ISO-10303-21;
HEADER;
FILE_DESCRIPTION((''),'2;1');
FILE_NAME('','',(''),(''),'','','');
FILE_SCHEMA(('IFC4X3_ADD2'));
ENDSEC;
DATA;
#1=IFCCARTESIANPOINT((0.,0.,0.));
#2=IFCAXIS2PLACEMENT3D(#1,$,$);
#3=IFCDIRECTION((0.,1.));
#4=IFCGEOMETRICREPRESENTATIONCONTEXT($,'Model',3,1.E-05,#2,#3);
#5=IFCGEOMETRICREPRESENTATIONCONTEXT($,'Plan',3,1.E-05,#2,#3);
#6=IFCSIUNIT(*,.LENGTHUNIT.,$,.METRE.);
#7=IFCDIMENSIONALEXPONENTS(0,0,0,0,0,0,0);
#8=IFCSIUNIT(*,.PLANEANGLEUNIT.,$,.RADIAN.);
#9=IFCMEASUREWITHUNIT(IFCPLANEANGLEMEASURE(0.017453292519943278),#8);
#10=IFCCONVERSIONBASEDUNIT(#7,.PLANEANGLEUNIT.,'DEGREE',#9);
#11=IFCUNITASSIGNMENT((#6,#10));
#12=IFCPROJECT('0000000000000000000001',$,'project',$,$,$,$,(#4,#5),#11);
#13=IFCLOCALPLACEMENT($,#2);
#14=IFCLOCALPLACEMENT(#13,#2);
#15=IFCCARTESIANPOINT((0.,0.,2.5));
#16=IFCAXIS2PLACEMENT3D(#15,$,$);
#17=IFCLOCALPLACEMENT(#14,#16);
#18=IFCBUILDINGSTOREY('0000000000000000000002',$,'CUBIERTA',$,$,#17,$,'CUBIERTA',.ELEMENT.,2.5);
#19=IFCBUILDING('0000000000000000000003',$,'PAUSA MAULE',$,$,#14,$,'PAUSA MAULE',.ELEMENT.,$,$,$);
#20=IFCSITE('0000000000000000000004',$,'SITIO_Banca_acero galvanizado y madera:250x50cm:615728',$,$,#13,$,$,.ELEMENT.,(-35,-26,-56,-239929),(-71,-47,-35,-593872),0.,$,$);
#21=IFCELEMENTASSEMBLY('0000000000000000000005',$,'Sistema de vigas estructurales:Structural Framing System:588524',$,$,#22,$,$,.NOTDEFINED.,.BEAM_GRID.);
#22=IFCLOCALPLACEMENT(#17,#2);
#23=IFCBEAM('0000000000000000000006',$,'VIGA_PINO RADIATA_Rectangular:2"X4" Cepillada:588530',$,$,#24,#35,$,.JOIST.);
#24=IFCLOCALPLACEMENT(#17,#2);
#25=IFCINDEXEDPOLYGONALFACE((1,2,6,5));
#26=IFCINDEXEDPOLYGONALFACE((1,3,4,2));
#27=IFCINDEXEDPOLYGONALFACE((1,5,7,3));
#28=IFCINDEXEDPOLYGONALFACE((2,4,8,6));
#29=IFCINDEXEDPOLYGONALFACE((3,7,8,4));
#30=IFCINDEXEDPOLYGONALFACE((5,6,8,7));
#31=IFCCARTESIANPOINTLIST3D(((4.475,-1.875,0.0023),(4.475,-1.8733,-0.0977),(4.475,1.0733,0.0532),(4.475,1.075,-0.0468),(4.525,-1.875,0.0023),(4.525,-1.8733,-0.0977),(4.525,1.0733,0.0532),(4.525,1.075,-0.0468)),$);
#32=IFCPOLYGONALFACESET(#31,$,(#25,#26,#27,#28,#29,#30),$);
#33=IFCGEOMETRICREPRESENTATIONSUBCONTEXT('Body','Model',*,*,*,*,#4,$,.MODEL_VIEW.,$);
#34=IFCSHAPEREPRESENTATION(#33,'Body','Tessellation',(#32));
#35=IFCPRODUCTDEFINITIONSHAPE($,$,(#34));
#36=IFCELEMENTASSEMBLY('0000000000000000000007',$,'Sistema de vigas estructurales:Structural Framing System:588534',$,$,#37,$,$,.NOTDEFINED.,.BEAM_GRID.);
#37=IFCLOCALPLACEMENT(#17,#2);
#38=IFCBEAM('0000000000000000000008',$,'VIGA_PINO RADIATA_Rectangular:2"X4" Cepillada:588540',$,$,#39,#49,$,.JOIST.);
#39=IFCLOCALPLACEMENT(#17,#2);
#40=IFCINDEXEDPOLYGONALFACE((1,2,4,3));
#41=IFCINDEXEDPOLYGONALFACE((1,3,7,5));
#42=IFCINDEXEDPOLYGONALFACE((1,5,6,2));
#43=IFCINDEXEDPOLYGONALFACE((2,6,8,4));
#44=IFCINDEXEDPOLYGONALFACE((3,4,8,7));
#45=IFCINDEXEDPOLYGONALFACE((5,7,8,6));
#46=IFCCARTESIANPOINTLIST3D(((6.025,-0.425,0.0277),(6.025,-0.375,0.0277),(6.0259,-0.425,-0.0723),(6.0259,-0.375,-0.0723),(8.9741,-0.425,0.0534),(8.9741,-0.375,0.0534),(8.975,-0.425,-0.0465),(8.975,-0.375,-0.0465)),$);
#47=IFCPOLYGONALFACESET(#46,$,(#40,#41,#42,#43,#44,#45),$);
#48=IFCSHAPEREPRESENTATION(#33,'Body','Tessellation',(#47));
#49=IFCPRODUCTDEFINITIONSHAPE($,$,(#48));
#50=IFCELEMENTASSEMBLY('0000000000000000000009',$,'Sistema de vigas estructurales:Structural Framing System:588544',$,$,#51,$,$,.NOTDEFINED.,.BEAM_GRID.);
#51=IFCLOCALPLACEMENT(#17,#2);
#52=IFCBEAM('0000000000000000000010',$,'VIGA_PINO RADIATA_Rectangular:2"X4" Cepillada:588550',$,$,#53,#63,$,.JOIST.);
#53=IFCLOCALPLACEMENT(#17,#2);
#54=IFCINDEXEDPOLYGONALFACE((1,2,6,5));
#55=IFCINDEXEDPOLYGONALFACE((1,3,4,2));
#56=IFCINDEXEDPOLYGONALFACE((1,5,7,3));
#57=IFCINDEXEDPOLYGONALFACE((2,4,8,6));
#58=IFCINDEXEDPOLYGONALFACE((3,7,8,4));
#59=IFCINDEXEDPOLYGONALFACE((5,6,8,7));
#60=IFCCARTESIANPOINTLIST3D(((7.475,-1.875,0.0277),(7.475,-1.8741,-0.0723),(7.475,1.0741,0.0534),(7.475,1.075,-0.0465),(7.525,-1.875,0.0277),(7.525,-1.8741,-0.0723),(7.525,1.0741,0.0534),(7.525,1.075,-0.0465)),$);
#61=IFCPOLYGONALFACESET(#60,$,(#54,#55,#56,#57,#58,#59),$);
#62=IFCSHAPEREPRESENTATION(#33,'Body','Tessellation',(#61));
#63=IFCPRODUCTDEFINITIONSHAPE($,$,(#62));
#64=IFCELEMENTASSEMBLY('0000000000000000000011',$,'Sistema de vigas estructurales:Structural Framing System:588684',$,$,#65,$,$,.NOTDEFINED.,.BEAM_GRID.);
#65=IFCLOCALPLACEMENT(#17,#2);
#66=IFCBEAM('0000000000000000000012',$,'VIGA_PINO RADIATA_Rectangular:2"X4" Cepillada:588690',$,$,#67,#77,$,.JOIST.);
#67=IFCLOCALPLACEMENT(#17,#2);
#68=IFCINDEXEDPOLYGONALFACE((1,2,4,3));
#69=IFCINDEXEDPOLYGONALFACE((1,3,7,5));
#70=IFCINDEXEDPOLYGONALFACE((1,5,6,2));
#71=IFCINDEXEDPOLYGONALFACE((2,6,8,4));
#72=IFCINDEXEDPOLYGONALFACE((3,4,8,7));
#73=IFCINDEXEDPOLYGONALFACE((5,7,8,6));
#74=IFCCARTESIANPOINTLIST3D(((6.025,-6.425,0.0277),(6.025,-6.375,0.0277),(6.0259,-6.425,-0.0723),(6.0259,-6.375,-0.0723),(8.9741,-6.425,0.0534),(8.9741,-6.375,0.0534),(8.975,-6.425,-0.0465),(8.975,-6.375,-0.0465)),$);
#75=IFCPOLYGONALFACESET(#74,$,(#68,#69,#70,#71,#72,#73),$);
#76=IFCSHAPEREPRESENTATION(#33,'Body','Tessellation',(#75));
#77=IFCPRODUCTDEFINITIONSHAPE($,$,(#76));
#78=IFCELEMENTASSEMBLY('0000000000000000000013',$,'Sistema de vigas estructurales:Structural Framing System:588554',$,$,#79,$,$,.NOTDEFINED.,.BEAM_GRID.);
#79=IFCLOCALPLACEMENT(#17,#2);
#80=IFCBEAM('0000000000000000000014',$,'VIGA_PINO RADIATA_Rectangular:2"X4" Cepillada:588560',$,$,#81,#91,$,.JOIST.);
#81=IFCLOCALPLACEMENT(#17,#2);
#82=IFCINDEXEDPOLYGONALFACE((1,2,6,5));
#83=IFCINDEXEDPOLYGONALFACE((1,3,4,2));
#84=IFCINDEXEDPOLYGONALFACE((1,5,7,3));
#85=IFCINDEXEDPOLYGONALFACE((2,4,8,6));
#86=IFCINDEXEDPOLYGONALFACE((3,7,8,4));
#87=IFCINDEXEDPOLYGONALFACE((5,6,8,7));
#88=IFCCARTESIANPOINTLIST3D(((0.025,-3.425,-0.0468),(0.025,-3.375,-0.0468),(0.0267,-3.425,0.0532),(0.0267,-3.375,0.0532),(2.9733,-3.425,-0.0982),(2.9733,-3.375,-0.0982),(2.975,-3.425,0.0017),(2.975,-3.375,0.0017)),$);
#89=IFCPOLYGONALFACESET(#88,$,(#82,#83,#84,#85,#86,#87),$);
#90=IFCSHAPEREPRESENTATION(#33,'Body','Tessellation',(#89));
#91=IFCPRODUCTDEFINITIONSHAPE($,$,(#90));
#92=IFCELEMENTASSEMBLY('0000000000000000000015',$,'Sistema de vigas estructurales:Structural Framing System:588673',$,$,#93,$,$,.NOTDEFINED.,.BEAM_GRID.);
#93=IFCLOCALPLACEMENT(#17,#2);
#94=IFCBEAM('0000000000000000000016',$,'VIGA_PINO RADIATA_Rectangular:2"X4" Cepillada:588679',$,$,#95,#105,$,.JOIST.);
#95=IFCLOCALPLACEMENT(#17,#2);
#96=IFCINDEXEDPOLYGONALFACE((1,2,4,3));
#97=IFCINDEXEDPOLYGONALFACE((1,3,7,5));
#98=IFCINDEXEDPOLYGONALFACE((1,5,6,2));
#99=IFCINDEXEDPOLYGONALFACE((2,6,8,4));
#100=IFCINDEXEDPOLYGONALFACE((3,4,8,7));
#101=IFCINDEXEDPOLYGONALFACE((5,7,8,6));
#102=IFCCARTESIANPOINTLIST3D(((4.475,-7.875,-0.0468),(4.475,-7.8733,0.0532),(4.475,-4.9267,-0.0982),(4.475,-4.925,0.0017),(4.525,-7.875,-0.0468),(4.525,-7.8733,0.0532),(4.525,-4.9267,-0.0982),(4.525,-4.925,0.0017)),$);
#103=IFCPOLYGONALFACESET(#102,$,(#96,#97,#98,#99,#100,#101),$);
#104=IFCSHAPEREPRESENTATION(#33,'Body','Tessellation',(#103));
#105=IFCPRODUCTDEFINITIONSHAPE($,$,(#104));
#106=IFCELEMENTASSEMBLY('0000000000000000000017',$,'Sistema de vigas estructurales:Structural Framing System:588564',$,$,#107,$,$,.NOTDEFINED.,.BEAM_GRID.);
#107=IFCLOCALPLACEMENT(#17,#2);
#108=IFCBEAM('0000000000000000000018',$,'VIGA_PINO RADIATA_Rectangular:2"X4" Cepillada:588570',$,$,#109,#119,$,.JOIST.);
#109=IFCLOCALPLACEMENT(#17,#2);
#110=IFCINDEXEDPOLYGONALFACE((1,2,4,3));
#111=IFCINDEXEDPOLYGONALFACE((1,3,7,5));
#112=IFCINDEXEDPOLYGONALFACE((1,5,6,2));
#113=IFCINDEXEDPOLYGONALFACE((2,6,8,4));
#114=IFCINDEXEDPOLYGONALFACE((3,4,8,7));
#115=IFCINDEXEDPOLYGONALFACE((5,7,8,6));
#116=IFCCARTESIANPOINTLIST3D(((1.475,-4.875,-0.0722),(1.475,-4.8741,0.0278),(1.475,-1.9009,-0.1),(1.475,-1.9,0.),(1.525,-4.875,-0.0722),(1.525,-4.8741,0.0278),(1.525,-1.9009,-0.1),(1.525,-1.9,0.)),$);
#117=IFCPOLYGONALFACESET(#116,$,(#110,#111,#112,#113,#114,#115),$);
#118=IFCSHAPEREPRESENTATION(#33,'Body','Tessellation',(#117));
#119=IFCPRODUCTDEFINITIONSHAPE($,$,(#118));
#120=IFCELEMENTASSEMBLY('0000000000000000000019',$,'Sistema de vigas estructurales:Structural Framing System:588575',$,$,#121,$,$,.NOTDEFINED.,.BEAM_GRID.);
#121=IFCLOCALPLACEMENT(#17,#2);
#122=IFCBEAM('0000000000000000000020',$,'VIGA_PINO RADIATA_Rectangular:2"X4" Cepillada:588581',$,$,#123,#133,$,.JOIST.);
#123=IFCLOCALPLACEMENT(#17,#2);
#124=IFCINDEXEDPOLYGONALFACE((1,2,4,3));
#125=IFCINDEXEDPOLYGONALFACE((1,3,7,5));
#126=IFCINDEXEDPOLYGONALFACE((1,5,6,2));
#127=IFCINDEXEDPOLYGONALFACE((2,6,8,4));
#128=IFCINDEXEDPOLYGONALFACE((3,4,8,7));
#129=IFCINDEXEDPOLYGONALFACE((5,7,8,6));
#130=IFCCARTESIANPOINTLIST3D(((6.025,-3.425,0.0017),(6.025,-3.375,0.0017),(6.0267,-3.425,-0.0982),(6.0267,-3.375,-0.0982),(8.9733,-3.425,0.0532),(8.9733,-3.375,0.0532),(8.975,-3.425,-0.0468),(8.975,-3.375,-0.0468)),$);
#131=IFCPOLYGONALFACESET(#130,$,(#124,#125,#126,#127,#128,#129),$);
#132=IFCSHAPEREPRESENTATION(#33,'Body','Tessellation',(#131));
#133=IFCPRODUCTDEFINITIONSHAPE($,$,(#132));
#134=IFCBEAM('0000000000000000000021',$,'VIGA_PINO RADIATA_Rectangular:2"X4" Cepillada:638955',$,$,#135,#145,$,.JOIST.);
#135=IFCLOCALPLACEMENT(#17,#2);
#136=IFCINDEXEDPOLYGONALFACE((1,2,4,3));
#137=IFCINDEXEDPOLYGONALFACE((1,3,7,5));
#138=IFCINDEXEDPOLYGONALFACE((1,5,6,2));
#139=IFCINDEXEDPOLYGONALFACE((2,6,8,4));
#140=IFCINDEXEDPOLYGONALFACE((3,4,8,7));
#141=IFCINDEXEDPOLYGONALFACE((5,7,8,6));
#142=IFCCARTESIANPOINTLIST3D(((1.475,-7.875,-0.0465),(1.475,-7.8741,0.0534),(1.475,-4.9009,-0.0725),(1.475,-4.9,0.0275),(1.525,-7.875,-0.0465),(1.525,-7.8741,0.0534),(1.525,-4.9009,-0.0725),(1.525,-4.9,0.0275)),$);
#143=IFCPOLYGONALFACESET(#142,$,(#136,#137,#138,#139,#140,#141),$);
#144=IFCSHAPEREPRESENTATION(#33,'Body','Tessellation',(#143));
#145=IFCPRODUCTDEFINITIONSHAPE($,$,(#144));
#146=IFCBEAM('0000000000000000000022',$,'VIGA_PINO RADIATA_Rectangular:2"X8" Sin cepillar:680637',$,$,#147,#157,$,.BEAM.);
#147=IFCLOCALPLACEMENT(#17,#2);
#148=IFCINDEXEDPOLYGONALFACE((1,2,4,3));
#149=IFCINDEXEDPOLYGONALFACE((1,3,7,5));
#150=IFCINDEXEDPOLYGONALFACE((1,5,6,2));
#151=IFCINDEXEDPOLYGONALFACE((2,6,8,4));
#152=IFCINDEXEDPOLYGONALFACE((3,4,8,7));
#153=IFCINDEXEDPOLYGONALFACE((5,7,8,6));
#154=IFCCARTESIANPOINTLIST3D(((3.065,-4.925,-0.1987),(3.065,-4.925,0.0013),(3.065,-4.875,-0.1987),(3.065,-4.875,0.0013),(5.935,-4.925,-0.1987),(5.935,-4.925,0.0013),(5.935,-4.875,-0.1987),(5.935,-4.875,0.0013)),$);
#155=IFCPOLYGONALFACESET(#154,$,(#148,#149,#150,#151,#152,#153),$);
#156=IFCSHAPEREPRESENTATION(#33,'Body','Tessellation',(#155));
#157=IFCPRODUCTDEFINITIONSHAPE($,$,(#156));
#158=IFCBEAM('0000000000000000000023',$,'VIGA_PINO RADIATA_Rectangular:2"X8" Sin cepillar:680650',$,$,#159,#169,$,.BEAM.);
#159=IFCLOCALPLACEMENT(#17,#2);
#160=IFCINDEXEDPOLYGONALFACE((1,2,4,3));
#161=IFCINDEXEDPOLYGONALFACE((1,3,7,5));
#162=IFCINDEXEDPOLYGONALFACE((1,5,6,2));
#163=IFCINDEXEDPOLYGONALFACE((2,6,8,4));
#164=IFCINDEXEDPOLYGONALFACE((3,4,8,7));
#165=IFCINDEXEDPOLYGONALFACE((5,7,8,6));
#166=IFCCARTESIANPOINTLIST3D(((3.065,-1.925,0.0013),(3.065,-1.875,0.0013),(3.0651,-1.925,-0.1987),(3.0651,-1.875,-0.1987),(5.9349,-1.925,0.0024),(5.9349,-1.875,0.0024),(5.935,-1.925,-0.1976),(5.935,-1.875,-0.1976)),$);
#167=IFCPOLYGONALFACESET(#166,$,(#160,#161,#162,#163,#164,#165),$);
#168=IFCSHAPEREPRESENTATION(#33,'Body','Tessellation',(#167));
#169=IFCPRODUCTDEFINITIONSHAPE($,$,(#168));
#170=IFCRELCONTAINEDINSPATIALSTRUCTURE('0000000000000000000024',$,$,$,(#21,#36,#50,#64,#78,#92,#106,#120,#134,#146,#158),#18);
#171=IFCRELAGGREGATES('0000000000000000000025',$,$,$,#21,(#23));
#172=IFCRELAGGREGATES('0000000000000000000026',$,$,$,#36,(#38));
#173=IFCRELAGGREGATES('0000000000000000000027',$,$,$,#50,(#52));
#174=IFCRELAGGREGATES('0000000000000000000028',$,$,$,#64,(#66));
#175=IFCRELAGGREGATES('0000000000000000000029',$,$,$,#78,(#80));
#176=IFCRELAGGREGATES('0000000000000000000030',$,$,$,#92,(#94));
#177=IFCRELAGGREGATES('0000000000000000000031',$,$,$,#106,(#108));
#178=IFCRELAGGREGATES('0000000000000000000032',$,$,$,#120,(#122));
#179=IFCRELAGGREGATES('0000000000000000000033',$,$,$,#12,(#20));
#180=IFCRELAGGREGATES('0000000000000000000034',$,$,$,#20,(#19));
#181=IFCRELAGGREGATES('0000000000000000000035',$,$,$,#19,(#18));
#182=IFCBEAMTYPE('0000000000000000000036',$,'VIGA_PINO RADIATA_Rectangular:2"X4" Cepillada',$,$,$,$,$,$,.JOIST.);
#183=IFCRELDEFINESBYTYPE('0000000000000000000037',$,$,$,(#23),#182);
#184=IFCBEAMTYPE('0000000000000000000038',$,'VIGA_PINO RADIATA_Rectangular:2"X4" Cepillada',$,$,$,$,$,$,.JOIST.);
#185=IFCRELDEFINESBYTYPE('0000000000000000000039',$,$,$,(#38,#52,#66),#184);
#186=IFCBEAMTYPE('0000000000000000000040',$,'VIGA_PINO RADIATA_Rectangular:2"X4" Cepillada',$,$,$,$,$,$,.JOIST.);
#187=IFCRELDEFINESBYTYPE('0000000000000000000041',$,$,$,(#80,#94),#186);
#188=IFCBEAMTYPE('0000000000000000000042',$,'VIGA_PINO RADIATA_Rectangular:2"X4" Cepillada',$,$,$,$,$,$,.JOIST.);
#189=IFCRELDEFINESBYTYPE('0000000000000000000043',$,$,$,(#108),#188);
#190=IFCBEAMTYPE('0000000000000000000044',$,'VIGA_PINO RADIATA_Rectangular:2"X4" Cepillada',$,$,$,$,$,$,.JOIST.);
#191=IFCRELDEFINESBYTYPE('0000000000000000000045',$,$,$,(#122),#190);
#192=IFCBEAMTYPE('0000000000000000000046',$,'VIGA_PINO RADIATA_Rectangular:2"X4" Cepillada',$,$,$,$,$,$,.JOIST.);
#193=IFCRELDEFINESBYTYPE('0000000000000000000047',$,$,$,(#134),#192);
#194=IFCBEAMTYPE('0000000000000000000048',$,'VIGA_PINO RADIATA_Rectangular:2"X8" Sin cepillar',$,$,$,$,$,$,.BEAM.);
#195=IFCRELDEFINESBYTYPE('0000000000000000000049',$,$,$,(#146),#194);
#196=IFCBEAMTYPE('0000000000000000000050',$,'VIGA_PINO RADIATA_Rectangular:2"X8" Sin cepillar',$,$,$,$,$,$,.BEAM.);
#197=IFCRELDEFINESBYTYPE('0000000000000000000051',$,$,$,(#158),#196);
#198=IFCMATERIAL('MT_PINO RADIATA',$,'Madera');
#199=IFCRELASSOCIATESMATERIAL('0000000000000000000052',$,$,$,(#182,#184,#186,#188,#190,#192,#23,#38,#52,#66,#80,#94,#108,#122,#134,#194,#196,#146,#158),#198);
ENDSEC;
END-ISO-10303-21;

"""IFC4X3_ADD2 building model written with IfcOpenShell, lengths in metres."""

from ifc_helpers import new_model, entity, si_unit, converted_unit, direction, frame, origin, origin_2d_with_axis, place, context, subcontext, project, spatial, rectangle, extrude, source, transform, mapped, material, material_profile, profile_set, profile_usage, type_object, type_shapes, element, aggregate, save


model = new_model("IFC4X3_ADD2")

# Units and contexts
model_context = context("Model", 3, precision=1e-05, world=origin(), true_north=direction((0.0, 1.0)))
plan_context = context("Plan", 3, precision=1e-05, world=origin(), true_north=direction((0.0, 1.0)))
body_context = subcontext(model_context, "Body", "Model", "MODEL_VIEW")
ifc_project = project(units=[si_unit("LENGTHUNIT", "METRE"), converted_unit("PLANEANGLEUNIT", "DEGREE", entity("IfcPlaneAngleMeasure", 0.017453292519943278), si_unit("PLANEANGLEUNIT", "RADIAN"), dimensions=[0, 0, 0, 0, 0, 0, 0])], contexts=[model_context, plan_context])

# Site, building, storey
site_placement = place(None, origin())
site = spatial("IfcSite", under=ifc_project, at=site_placement, Name="SITIO_Banca_acero galvanizado y madera:250x50cm:615728", CompositionType="ELEMENT", RefLatitude=(-35, -26, -56, -239929), RefLongitude=(-71, -47, -35, -593872), RefElevation=0.0)
building_placement = place(site_placement, origin())
building = spatial("IfcBuilding", under=site, at=building_placement, Name="PAUSA MAULE", LongName="PAUSA MAULE", CompositionType="ELEMENT")
storey_placement = place(building_placement, frame((0.0, 0.0, 2.5)))
storey = spatial("IfcBuildingStorey", under=building, at=storey_placement, Name="CUBIERTA", LongName="CUBIERTA", CompositionType="ELEMENT", Elevation=2.5)

# Shared definitions
ifc_material_1 = material(Name="MT_PINO RADIATA", Category="Madera")
ifc_material_profile_1 = material_profile(ifc_material_1, rectangle(XDim=8.87, YDim=0.05, at=origin_2d_with_axis()), Name="2\"X8\" Sin cepillar")
ifc_profile_set_1 = profile_set([ifc_material_profile_1], Name="2\"X8\" Sin cepillar")
ifc_profile_usage_1 = profile_usage(ifc_profile_set_1, cardinal=8)

# Element assemblies, beams
ifc_material_profile_2 = material_profile(ifc_material_1, rectangle(XDim=2.9493, YDim=0.05, at=origin_2d_with_axis()), Name="2\"X4\" Cepillada")
ifc_profile_set_2 = profile_set([ifc_material_profile_2], Name="2\"X4\" Cepillada")
ifc_profile_usage_2 = profile_usage(ifc_profile_set_2, cardinal=8)
assembly_1_placement = place(storey_placement, origin())
assembly_1 = element("IfcElementAssembly", 1, at=assembly_1_placement, inside=storey, Name="Sistema de vigas estructurales:Structural Framing System:588524", AssemblyPlace="NOTDEFINED", PredefinedType="BEAM_GRID")
beam_type_1 = type_object("IfcBeamType", Name="VIGA_PINO RADIATA_Rectangular:2\"X4\" Cepillada", PredefinedType="JOIST", material=ifc_profile_set_2)
shared_shape_1 = source(origin(), body_context, "Body", "SweptSolid", [
    extrude(rectangle(XDim=2.9487, YDim=0.05, at=origin_2d_with_axis()), frame((-0.0009, 0.0, -0.05), z_axis=(0.0, 0.0, 1.0), x_axis=(-1.0, 0.0, 0.0)), (0.0, 0.0, 1.0), 0.1),
])
type_shapes(beam_type_1, [shared_shape_1])
beam_1_placement = place(assembly_1_placement, frame((4.5, -0.3991, -0.0222), z_axis=(0.0, -0.017272, 0.999851), x_axis=(0.0, 0.999851, 0.017272)))
beam_1 = element("IfcBeam", 2, at=beam_1_placement, type_object=beam_type_1, material=ifc_profile_usage_2, Name="VIGA_PINO RADIATA_Rectangular:2\"X4\" Cepillada:588530", PredefinedType="JOIST", context=body_context, shape_type="MappedRepresentation", body=[
    mapped(shared_shape_1, transform((0.0, 0.0, 0.0), scale=1.0)),
])
aggregate(assembly_1, [beam_1])
assembly_2_placement = place(storey_placement, origin())
assembly_2 = element("IfcElementAssembly", 3, at=assembly_2_placement, inside=storey, Name="Sistema de vigas estructurales:Structural Framing System:588534", AssemblyPlace="NOTDEFINED", PredefinedType="BEAM_GRID")
beam_type_2 = type_object("IfcBeamType", Name="VIGA_PINO RADIATA_Rectangular:2\"X4\" Cepillada", PredefinedType="JOIST", material=ifc_profile_set_2)
shared_shape_2 = source(origin(), body_context, "Body", "SweptSolid", [
    extrude(rectangle(XDim=2.9492, YDim=0.05, at=origin_2d_with_axis()), frame((-0.0004, 0.0, -0.05), z_axis=(0.0, 0.0, 1.0), x_axis=(-1.0, 0.0, 0.0)), (0.0, 0.0, 1.0), 0.1),
])
type_shapes(beam_type_2, [shared_shape_2])
beam_2_placement = place(assembly_2_placement, frame((7.5004, -0.4, -0.0094), z_axis=(-0.008727, 0.0, 0.999962), x_axis=(0.999962, 0.0, 0.008727)))
beam_2 = element("IfcBeam", 4, at=beam_2_placement, type_object=beam_type_2, material=ifc_profile_usage_2, Name="VIGA_PINO RADIATA_Rectangular:2\"X4\" Cepillada:588540", PredefinedType="JOIST", context=body_context, shape_type="MappedRepresentation", body=[
    mapped(shared_shape_2, transform((0.0, 0.0, 0.0), scale=1.0)),
])
aggregate(assembly_2, [beam_2])
assembly_3_placement = place(storey_placement, origin())
assembly_3 = element("IfcElementAssembly", 5, at=assembly_3_placement, inside=storey, Name="Sistema de vigas estructurales:Structural Framing System:588544", AssemblyPlace="NOTDEFINED", PredefinedType="BEAM_GRID")
beam_3_placement = place(assembly_3_placement, frame((7.5, -0.3996, -0.0094), z_axis=(0.0, -0.008727, 0.999962), x_axis=(0.0, 0.999962, 0.008727)))
beam_3 = element("IfcBeam", 6, at=beam_3_placement, type_object=beam_type_2, material=ifc_profile_usage_2, Name="VIGA_PINO RADIATA_Rectangular:2\"X4\" Cepillada:588550", PredefinedType="JOIST", context=body_context, shape_type="MappedRepresentation", body=[
    mapped(shared_shape_2, transform((0.0, 0.0, 0.0), scale=1.0)),
])
aggregate(assembly_3, [beam_3])
assembly_4_placement = place(storey_placement, origin())
assembly_4 = element("IfcElementAssembly", 7, at=assembly_4_placement, inside=storey, Name="Sistema de vigas estructurales:Structural Framing System:588684", AssemblyPlace="NOTDEFINED", PredefinedType="BEAM_GRID")
beam_4_placement = place(assembly_4_placement, frame((7.5004, -6.4, -0.0094), z_axis=(-0.008727, 0.0, 0.999962), x_axis=(0.999962, 0.0, 0.008727)))
beam_4 = element("IfcBeam", 8, at=beam_4_placement, type_object=beam_type_2, material=ifc_profile_usage_2, Name="VIGA_PINO RADIATA_Rectangular:2\"X4\" Cepillada:588690", PredefinedType="JOIST", context=body_context, shape_type="MappedRepresentation", body=[
    mapped(shared_shape_2, transform((0.0, 0.0, 0.0), scale=1.0)),
])
aggregate(assembly_4, [beam_4])
assembly_5_placement = place(storey_placement, origin())
assembly_5 = element("IfcElementAssembly", 9, at=assembly_5_placement, inside=storey, Name="Sistema de vigas estructurales:Structural Framing System:588554", AssemblyPlace="NOTDEFINED", PredefinedType="BEAM_GRID")
beam_type_3 = type_object("IfcBeamType", Name="VIGA_PINO RADIATA_Rectangular:2\"X4\" Cepillada", PredefinedType="JOIST", material=ifc_profile_set_2)
shared_shape_3 = source(origin(), body_context, "Body", "SweptSolid", [
    extrude(rectangle(XDim=2.9487, YDim=0.05, at=origin_2d_with_axis()), frame((0.0009, 0.0, -0.05), z_axis=(0.0, 0.0, 1.0), x_axis=(-1.0, 0.0, 0.0)), (0.0, 0.0, 1.0), 0.1),
])
type_shapes(beam_type_3, [shared_shape_3])
beam_5_placement = place(assembly_5_placement, frame((1.4991, -3.4, -0.0225), z_axis=(0.017452, 0.0, 0.999848), x_axis=(0.999848, 0.0, -0.017452)))
beam_5 = element("IfcBeam", 10, at=beam_5_placement, type_object=beam_type_3, material=ifc_profile_usage_2, Name="VIGA_PINO RADIATA_Rectangular:2\"X4\" Cepillada:588560", PredefinedType="JOIST", context=body_context, shape_type="MappedRepresentation", body=[
    mapped(shared_shape_3, transform((0.0, 0.0, 0.0), scale=1.0)),
])
aggregate(assembly_5, [beam_5])
assembly_6_placement = place(storey_placement, origin())
assembly_6 = element("IfcElementAssembly", 11, at=assembly_6_placement, inside=storey, Name="Sistema de vigas estructurales:Structural Framing System:588673", AssemblyPlace="NOTDEFINED", PredefinedType="BEAM_GRID")
beam_6_placement = place(assembly_6_placement, frame((4.5, -6.4009, -0.0225), z_axis=(0.0, 0.017452, 0.999848), x_axis=(0.0, 0.999848, -0.017452)))
beam_6 = element("IfcBeam", 12, at=beam_6_placement, type_object=beam_type_3, material=ifc_profile_usage_2, Name="VIGA_PINO RADIATA_Rectangular:2\"X4\" Cepillada:588679", PredefinedType="JOIST", context=body_context, shape_type="MappedRepresentation", body=[
    mapped(shared_shape_3, transform((0.0, 0.0, 0.0), scale=1.0)),
])
aggregate(assembly_6, [beam_6])
assembly_7_placement = place(storey_placement, origin())
assembly_7 = element("IfcElementAssembly", 13, at=assembly_7_placement, inside=storey, Name="Sistema de vigas estructurales:Structural Framing System:588564", AssemblyPlace="NOTDEFINED", PredefinedType="BEAM_GRID")
beam_type_4 = type_object("IfcBeamType", Name="VIGA_PINO RADIATA_Rectangular:2\"X4\" Cepillada", PredefinedType="JOIST", material=ifc_profile_set_2)
shared_shape_4 = source(origin(), body_context, "Body", "SweptSolid", [
    extrude(rectangle(XDim=2.9742, YDim=0.05, at=origin_2d_with_axis()), frame((0.013, 0.0, -0.05), z_axis=(0.0, 0.0, 1.0), x_axis=(-1.0, 0.0, 0.0)), (0.0, 0.0, 1.0), 0.1),
])
type_shapes(beam_type_4, [shared_shape_4])
beam_7_placement = place(assembly_7_placement, frame((1.5, -3.4005, -0.036), z_axis=(0.0, 0.009344, 0.999956), x_axis=(0.0, 0.999956, -0.009344)))
beam_7 = element("IfcBeam", 14, at=beam_7_placement, type_object=beam_type_4, material=ifc_profile_usage_2, Name="VIGA_PINO RADIATA_Rectangular:2\"X4\" Cepillada:588570", PredefinedType="JOIST", context=body_context, shape_type="MappedRepresentation", body=[
    mapped(shared_shape_4, transform((0.0, 0.0, 0.0), scale=1.0)),
])
aggregate(assembly_7, [beam_7])
assembly_8_placement = place(storey_placement, origin())
assembly_8 = element("IfcElementAssembly", 15, at=assembly_8_placement, inside=storey, Name="Sistema de vigas estructurales:Structural Framing System:588575", AssemblyPlace="NOTDEFINED", PredefinedType="BEAM_GRID")
beam_type_5 = type_object("IfcBeamType", Name="VIGA_PINO RADIATA_Rectangular:2\"X4\" Cepillada", PredefinedType="JOIST", material=ifc_profile_set_2)
shared_shape_5 = source(origin(), body_context, "Body", "SweptSolid", [
    extrude(rectangle(XDim=2.9487, YDim=0.05, at=origin_2d_with_axis()), frame((-0.0009, 0.0, -0.05), z_axis=(0.0, 0.0, 1.0), x_axis=(-1.0, 0.0, 0.0)), (0.0, 0.0, 1.0), 0.1),
])
type_shapes(beam_type_5, [shared_shape_5])
beam_8_placement = place(assembly_8_placement, frame((7.5009, -3.4, -0.0225), z_axis=(-0.017452, 0.0, 0.999848), x_axis=(0.999848, 0.0, 0.017452)))
beam_8 = element("IfcBeam", 16, at=beam_8_placement, type_object=beam_type_5, material=ifc_profile_usage_2, Name="VIGA_PINO RADIATA_Rectangular:2\"X4\" Cepillada:588581", PredefinedType="JOIST", context=body_context, shape_type="MappedRepresentation", body=[
    mapped(shared_shape_5, transform((0.0, 0.0, 0.0), scale=1.0)),
])
aggregate(assembly_8, [beam_8])

# Beams
beam_type_6 = type_object("IfcBeamType", Name="VIGA_PINO RADIATA_Rectangular:2\"X4\" Cepillada", PredefinedType="JOIST", material=ifc_profile_set_2)
shared_shape_6 = source(origin(), body_context, "Body", "SweptSolid", [
    extrude(rectangle(XDim=2.9742, YDim=0.05, at=origin_2d_with_axis()), frame((0.0129, 0.0, -0.05), z_axis=(0.0, 0.0, 1.0), x_axis=(-1.0, 0.0, 0.0)), (0.0, 0.0, 1.0), 0.1),
])
type_shapes(beam_type_6, [shared_shape_6])
beam_9_placement = place(storey_placement, frame((1.5, -6.4004, -0.0094), z_axis=(0.0, 0.008727, 0.999962), x_axis=(0.0, 0.999962, -0.008727)))
element("IfcBeam", 17, at=beam_9_placement, inside=storey, type_object=beam_type_6, material=ifc_profile_usage_2, Name="VIGA_PINO RADIATA_Rectangular:2\"X4\" Cepillada:638955", PredefinedType="JOIST", context=body_context, shape_type="MappedRepresentation", body=[
    mapped(shared_shape_6, transform((0.0, 0.0, 0.0), scale=1.0)),
])
beam_type_7 = type_object("IfcBeamType", Name="VIGA_PINO RADIATA_Rectangular:2\"X8\" Sin cepillar", PredefinedType="BEAM", material=ifc_profile_set_1)
shared_shape_7 = source(origin(), body_context, "Body", "SweptSolid", [
    extrude(rectangle(XDim=2.87, YDim=0.05, at=origin_2d_with_axis()), frame((0.0, 0.0, -0.1), z_axis=(0.0, 0.0, 1.0), x_axis=(-1.0, 0.0, 0.0)), (0.0, 0.0, 1.0), 0.2),
])
type_shapes(beam_type_7, [shared_shape_7])
beam_10_placement = place(storey_placement, frame((4.5, -4.9, -0.0987)))
element("IfcBeam", 18, at=beam_10_placement, inside=storey, type_object=beam_type_7, material=ifc_profile_usage_1, Name="VIGA_PINO RADIATA_Rectangular:2\"X8\" Sin cepillar:680637", PredefinedType="BEAM", context=body_context, shape_type="MappedRepresentation", body=[
    mapped(shared_shape_7, transform((0.0, 0.0, 0.0), scale=1.0)),
])
beam_type_8 = type_object("IfcBeamType", Name="VIGA_PINO RADIATA_Rectangular:2\"X8\" Sin cepillar", PredefinedType="BEAM", material=ifc_profile_set_1)
shared_shape_8 = source(origin(), body_context, "Body", "SweptSolid", [
    extrude(rectangle(XDim=2.8699, YDim=0.05, at=origin_2d_with_axis()), frame((-0.065, 0.0, -0.1), z_axis=(0.0, 0.0, 1.0), x_axis=(-1.0, 0.0, 0.0)), (0.0, 0.0, 1.0), 0.2),
])
type_shapes(beam_type_8, [shared_shape_8])
beam_11_placement = place(storey_placement, frame((4.565, -1.9, -0.0981), z_axis=(-0.000378, 0.0, 1.0), x_axis=(1.0, 0.0, 0.000378)))
element("IfcBeam", 19, at=beam_11_placement, inside=storey, type_object=beam_type_8, material=ifc_profile_usage_1, Name="VIGA_PINO RADIATA_Rectangular:2\"X8\" Sin cepillar:680650", PredefinedType="BEAM", context=body_context, shape_type="MappedRepresentation", body=[
    mapped(shared_shape_8, transform((0.0, 0.0, 0.0), scale=1.0)),
])

save(model, "model.ifc")
